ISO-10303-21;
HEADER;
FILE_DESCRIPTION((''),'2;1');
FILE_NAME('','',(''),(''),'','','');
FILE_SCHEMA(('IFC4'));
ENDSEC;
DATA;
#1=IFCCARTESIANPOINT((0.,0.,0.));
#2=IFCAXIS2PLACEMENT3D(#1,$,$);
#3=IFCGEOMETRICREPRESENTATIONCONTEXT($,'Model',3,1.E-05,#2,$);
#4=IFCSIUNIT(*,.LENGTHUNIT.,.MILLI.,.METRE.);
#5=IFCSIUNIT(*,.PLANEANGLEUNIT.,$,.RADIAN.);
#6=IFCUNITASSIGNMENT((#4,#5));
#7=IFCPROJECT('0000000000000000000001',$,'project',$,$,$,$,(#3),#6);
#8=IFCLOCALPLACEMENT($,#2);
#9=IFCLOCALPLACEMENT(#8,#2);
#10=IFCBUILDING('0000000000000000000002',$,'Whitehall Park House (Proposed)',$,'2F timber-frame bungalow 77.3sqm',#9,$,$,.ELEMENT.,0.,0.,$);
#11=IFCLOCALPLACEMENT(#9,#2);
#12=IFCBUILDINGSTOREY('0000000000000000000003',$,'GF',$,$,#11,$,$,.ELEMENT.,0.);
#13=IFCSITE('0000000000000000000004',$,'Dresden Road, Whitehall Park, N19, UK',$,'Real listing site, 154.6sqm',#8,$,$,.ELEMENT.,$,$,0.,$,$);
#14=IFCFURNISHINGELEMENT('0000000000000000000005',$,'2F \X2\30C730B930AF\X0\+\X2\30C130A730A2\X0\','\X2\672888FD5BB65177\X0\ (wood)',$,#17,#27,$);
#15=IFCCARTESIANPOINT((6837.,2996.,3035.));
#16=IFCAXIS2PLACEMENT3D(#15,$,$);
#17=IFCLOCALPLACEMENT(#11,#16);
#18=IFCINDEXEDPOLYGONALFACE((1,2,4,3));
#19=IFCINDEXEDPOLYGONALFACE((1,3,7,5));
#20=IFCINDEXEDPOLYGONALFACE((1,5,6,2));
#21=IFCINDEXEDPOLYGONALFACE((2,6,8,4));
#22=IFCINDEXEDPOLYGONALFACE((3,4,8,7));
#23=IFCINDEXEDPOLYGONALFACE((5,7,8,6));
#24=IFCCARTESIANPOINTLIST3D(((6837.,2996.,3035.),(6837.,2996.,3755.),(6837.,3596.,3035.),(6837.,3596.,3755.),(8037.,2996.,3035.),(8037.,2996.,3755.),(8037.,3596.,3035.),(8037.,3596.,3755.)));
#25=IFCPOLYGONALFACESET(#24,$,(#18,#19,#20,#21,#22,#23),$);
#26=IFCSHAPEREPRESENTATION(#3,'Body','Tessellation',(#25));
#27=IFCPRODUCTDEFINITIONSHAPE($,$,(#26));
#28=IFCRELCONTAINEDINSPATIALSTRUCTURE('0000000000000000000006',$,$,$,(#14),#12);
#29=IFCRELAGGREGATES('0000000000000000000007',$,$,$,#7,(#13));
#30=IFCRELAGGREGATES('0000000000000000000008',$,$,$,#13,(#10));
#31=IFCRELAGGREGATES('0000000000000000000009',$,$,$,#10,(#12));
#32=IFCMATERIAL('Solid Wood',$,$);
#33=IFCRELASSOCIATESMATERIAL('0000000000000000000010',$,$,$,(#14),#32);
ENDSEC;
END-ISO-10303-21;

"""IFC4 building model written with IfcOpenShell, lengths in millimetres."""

from ifc_helpers import new_model, si_unit, frame, frame_2d, origin, place, context, project, spatial, rectangle, extrude, material, element, save


model = new_model("IFC4")

# Units and contexts
model_context = context("Model", 3, precision=1e-05, world=origin())
ifc_project = project(units=[si_unit("LENGTHUNIT", "METRE", prefix="MILLI"), si_unit("PLANEANGLEUNIT", "RADIAN")], contexts=[model_context])

# Site, building, storey
site_placement = place(None, origin())
site = spatial("IfcSite", under=ifc_project, at=site_placement, Name="Dresden Road, Whitehall Park, N19, UK", ObjectType="Real listing site, 154.6sqm", CompositionType="ELEMENT", RefElevation=0.0)
building_placement = place(site_placement, origin())
building = spatial("IfcBuilding", under=site, at=building_placement, Name="Whitehall Park House (Proposed)", ObjectType="2F timber-frame bungalow 77.3sqm", CompositionType="ELEMENT", ElevationOfRefHeight=0.0, ElevationOfTerrain=0.0)
storey_placement = place(building_placement, origin())
storey = spatial("IfcBuildingStorey", under=building, at=storey_placement, Name="GF", CompositionType="ELEMENT", Elevation=0.0)

# Shared definitions
ifc_material_1 = material(Name="Solid Wood")

# Furnishing element
furnishing_1_placement = place(storey_placement, frame((6837.0, 2996.0, 3035.0)))
element("IfcFurnishingElement", 1, at=furnishing_1_placement, inside=storey, material=ifc_material_1, Name="2F デスク+チェア", Description="木製家具 (wood)", context=model_context, shape_type="SweptSolid", body=[
    extrude(rectangle(XDim=1200.0, YDim=600.0, at=frame_2d((600.0, 300.0))), frame((6837.0, 2996.0, 3035.0)), (0.0, 0.0, 1.0), 720.0),
])

save(model, "model.ifc")
